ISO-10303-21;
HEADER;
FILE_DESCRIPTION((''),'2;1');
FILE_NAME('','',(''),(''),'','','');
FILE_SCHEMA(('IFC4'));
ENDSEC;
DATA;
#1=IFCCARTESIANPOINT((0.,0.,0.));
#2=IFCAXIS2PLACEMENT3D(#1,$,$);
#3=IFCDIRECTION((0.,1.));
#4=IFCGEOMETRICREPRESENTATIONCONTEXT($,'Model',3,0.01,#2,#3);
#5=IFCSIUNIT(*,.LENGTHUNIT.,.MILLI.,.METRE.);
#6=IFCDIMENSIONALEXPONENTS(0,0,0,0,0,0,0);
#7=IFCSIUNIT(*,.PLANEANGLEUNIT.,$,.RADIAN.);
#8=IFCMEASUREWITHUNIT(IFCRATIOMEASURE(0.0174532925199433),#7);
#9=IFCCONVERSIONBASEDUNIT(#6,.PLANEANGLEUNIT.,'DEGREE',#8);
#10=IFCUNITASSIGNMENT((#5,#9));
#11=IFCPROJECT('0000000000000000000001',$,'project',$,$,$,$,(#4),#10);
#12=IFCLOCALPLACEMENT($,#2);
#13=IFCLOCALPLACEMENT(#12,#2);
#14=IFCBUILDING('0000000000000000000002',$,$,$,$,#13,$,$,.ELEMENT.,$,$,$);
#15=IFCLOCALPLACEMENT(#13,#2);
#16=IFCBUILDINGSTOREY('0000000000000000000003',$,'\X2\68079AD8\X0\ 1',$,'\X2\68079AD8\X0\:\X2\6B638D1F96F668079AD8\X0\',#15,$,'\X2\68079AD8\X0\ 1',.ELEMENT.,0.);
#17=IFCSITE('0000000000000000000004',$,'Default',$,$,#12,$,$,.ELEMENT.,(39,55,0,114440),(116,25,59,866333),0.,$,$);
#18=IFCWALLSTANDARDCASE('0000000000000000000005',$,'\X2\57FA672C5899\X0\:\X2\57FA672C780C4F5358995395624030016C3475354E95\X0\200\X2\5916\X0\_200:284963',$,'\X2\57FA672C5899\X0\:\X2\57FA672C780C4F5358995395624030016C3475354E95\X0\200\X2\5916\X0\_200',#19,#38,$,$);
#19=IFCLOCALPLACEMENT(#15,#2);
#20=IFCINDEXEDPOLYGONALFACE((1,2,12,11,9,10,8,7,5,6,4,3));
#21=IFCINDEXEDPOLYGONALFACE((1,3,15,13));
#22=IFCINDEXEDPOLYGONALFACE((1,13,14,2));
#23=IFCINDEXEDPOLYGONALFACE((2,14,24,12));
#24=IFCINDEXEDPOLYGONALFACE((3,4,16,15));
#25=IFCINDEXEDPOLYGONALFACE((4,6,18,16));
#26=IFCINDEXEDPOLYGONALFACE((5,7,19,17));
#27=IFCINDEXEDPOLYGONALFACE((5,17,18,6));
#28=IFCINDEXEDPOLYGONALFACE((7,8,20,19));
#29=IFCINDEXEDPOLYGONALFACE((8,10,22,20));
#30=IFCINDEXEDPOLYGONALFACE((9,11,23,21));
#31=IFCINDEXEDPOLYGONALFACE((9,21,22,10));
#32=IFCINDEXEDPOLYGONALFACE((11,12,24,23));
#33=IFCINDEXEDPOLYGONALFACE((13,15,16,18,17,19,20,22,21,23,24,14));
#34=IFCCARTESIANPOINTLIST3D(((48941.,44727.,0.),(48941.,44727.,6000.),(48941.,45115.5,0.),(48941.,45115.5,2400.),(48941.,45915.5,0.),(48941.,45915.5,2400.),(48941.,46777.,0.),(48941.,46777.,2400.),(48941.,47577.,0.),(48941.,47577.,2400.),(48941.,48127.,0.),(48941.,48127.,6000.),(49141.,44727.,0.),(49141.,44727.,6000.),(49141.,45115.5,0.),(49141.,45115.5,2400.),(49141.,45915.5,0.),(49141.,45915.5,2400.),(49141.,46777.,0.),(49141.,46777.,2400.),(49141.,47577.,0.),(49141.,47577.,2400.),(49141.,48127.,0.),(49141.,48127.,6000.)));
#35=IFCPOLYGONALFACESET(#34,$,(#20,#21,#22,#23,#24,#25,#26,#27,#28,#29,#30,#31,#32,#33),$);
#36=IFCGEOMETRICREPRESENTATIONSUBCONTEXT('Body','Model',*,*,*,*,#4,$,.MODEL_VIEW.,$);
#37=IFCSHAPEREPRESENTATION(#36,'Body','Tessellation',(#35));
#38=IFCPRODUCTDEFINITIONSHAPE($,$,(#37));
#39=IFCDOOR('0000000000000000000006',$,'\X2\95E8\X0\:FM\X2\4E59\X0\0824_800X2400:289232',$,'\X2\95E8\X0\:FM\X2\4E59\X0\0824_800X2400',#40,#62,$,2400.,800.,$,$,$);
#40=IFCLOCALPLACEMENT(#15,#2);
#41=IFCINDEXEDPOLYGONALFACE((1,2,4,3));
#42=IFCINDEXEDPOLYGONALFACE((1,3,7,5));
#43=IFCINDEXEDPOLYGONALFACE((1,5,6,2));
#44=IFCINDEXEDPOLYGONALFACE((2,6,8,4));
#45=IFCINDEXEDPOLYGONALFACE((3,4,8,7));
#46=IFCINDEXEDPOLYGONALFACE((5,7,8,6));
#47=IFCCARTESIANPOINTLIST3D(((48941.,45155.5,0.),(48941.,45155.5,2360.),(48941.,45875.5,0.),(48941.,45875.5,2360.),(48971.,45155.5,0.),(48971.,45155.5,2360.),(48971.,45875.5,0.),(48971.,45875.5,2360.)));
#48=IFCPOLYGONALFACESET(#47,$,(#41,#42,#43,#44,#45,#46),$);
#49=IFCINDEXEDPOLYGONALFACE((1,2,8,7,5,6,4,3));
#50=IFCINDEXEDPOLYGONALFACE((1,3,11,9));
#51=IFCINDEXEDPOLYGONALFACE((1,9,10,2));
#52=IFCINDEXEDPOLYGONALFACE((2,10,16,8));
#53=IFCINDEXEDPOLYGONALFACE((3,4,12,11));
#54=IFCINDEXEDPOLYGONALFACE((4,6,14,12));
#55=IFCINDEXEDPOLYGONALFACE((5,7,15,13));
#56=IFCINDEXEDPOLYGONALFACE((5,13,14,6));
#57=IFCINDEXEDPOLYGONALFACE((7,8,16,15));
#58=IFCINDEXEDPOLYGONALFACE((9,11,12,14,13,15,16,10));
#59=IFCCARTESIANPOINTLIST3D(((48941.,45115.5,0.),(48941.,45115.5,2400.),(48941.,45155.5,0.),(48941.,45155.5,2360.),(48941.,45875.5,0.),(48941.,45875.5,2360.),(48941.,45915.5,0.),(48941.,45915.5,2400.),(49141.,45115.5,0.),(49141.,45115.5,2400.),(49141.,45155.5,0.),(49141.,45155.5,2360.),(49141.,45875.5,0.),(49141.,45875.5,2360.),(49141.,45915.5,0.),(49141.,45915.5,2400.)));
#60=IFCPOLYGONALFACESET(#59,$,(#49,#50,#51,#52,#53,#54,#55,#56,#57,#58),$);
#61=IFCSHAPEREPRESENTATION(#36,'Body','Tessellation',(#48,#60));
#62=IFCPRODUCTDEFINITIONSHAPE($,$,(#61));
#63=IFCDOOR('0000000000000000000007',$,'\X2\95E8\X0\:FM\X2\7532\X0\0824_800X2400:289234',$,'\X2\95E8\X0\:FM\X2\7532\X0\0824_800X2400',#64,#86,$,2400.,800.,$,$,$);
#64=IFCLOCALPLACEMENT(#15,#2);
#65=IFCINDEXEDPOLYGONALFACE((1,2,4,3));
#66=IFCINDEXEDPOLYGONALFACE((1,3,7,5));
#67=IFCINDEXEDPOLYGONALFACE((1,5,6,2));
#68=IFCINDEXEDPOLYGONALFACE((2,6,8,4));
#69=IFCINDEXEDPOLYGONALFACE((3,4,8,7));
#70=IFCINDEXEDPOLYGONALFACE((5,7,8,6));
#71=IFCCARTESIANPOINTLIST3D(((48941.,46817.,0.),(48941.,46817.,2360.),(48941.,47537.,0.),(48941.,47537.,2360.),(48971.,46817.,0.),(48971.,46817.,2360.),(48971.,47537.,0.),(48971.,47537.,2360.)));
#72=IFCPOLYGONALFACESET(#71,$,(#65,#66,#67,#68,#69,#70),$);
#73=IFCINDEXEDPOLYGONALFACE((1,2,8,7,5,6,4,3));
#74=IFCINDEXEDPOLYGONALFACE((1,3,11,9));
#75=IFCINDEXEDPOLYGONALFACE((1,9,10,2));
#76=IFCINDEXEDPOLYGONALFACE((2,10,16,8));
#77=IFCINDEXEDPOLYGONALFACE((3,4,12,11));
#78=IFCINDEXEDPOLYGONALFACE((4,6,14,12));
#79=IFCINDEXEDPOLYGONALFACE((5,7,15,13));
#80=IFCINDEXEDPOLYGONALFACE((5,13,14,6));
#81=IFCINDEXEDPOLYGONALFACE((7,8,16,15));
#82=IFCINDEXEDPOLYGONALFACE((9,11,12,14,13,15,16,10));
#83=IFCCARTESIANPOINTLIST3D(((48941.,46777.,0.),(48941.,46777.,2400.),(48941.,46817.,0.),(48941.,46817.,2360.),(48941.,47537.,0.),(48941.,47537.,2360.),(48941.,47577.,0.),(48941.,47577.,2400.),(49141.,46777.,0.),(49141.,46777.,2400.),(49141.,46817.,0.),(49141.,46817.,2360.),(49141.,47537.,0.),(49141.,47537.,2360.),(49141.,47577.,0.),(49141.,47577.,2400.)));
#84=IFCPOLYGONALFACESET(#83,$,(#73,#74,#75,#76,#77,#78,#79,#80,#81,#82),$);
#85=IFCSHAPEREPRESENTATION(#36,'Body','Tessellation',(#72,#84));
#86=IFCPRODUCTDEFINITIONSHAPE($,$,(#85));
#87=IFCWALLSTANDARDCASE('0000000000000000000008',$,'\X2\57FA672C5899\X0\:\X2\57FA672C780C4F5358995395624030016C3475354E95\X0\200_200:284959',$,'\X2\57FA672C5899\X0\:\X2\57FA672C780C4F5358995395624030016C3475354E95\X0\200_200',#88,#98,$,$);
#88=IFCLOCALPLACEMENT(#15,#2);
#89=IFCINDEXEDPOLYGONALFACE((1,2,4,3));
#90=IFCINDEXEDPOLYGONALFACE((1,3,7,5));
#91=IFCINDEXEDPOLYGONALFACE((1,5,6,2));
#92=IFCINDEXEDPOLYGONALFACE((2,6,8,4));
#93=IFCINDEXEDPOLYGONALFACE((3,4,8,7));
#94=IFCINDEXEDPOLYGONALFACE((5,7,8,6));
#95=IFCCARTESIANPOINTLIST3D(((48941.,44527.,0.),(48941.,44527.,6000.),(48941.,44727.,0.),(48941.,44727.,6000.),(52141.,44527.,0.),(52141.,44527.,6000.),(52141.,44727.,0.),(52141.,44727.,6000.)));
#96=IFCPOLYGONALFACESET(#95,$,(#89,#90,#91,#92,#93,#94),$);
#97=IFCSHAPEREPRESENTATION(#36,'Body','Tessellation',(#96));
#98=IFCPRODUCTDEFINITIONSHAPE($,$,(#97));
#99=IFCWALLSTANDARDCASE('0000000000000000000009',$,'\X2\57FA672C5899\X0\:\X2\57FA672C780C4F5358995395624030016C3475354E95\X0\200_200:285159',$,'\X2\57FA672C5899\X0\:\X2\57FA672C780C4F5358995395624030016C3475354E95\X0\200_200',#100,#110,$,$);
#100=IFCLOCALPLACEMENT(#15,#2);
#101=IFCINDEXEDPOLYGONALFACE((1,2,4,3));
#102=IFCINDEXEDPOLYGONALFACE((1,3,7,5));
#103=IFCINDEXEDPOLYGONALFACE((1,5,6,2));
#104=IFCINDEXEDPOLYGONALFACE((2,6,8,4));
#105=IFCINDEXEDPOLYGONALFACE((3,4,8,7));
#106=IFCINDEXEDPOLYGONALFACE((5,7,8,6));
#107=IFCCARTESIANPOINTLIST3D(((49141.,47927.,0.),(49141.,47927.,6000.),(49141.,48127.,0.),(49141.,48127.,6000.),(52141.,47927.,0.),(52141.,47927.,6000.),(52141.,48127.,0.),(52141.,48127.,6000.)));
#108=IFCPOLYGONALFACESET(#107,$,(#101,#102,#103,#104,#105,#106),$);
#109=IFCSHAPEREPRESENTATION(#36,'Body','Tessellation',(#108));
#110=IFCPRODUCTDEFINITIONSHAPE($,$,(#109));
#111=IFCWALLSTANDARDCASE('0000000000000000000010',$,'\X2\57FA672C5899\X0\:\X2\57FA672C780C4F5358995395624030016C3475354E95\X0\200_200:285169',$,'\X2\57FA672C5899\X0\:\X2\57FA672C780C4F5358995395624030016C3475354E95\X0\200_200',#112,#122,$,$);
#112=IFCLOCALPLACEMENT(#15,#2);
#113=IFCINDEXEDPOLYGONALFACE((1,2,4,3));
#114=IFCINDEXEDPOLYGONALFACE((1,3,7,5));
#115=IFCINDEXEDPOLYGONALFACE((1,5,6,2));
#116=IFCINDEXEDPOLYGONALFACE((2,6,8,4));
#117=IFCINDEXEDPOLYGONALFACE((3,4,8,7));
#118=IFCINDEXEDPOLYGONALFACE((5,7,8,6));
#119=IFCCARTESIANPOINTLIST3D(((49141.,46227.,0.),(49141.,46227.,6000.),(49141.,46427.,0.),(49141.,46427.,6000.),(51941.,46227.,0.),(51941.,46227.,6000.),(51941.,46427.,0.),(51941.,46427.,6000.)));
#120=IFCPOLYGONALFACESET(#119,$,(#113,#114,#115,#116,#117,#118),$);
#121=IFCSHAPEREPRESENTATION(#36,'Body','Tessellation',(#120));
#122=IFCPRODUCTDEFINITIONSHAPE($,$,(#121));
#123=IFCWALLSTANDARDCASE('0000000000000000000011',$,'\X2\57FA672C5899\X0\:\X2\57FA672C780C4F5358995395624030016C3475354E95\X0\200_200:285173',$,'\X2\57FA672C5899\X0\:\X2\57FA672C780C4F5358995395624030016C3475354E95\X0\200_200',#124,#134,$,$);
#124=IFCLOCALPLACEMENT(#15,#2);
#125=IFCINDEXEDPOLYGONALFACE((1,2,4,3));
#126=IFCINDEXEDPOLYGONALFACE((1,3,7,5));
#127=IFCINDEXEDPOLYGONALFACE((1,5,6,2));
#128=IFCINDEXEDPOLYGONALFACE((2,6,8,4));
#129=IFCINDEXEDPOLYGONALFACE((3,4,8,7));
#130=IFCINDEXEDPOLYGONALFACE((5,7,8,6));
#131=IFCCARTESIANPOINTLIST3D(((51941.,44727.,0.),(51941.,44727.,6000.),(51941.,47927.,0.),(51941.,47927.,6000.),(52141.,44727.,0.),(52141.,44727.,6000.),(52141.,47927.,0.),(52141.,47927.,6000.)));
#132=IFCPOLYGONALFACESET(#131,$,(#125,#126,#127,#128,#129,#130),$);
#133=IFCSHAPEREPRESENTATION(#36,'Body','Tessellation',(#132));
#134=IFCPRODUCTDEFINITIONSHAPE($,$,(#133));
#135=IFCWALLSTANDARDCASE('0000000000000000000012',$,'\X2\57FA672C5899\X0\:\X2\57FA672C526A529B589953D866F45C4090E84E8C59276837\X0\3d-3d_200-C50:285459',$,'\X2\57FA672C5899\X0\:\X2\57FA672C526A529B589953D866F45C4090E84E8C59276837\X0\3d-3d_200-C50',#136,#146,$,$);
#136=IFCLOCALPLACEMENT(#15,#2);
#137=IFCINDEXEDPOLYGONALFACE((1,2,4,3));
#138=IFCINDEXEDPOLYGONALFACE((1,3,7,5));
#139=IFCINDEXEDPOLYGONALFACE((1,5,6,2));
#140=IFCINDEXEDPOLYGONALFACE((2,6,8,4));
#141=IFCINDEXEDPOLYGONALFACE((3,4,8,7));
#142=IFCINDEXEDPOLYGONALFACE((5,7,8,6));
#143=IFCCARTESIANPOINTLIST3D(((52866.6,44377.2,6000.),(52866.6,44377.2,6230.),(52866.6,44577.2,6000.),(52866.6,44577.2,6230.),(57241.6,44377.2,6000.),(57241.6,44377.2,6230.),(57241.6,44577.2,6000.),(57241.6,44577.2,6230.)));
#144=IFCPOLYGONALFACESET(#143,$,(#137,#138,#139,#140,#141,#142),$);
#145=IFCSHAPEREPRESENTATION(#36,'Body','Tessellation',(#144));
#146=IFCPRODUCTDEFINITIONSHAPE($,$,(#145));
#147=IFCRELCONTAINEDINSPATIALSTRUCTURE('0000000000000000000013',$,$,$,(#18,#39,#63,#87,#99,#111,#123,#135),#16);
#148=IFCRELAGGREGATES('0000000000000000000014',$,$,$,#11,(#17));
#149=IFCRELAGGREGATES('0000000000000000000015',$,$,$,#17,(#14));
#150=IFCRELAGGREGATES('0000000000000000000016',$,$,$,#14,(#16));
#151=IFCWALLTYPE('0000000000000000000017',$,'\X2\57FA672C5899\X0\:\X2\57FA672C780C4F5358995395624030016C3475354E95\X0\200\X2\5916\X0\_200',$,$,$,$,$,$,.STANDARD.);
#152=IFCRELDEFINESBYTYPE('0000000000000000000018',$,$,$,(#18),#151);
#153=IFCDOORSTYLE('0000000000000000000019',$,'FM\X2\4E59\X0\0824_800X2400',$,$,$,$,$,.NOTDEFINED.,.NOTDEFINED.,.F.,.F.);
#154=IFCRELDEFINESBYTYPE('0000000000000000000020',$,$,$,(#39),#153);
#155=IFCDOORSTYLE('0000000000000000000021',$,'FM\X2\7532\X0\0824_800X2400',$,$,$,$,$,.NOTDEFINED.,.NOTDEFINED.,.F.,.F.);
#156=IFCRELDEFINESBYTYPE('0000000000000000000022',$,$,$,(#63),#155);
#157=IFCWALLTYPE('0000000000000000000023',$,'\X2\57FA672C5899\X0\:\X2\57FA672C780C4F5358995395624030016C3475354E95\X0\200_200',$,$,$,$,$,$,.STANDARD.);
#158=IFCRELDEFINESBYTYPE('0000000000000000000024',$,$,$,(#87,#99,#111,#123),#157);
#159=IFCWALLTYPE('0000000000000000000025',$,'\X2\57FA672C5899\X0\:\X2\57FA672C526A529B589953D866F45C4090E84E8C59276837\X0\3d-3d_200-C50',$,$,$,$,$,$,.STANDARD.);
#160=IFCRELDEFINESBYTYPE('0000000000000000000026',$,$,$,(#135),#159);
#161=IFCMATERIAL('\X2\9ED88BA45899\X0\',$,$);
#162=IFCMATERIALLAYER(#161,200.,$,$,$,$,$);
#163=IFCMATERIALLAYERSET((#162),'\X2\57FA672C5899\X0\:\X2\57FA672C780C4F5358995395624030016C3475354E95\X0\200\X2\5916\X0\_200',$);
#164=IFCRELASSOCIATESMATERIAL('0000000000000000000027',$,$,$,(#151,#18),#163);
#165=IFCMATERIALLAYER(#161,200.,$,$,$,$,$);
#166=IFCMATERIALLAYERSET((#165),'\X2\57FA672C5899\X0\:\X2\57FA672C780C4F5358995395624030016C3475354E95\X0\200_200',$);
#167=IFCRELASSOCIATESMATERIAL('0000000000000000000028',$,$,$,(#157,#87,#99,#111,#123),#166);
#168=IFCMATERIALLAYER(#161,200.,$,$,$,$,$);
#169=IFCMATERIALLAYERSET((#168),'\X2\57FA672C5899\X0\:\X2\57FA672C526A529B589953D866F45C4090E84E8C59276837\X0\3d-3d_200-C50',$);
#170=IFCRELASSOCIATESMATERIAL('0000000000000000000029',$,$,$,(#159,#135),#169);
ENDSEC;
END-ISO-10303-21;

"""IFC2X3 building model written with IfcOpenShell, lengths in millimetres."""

from ifc_helpers import new_model, entity, si_unit, converted_unit, direction, frame, frame_2d, origin, place, context, subcontext, project, spatial, polyline, rectangle, outline, extrude, source, transform, mapped, material, layer, layer_set, layer_usage, type_object, type_shapes, element, fill, save


model = new_model("IFC2X3")

# Units and contexts
model_context = context("Model", 3, precision=0.01, world=origin(), true_north=direction((0.0, 1.0)))
body_context = subcontext(model_context, "Body", "Model", "MODEL_VIEW")
ifc_project = project(units=[si_unit("LENGTHUNIT", "METRE", prefix="MILLI"), converted_unit("PLANEANGLEUNIT", "DEGREE", entity("IfcRatioMeasure", 0.0174532925199433), si_unit("PLANEANGLEUNIT", "RADIAN"), dimensions=[0, 0, 0, 0, 0, 0, 0])], contexts=[model_context])

# Site, building, storey
site_placement = place(None, origin())
site = spatial("IfcSite", under=ifc_project, at=site_placement, Name="Default", CompositionType="ELEMENT", RefLatitude=(39, 55, 0, 114440), RefLongitude=(116, 25, 59, 866333), RefElevation=0.0)
building_placement = place(site_placement, origin())
building = spatial("IfcBuilding", under=site, at=building_placement, CompositionType="ELEMENT")
storey_placement = place(building_placement, origin())
storey = spatial("IfcBuildingStorey", under=building, at=storey_placement, Name="标高 1", ObjectType="标高:正负零标高", LongName="标高 1", CompositionType="ELEMENT", Elevation=0.0)

# Shared definitions
ifc_material = material(Name="默认墙")

# Wall, openings, doors
ifc_layer_1 = layer(ifc_material, 200.0)
ifc_layer_set_1 = layer_set([ifc_layer_1], Name="基本墙:基本砌体墙厕所、水电井200外_200")
ifc_layer_usage_1 = layer_usage(ifc_layer_set_1, "AXIS2", "NEGATIVE", 100.0)
wall_type_1 = type_object("IfcWallType", Name="基本墙:基本砌体墙厕所、水电井200外_200", PredefinedType="STANDARD", material=ifc_layer_set_1)
wall_1_placement = place(building_placement, frame((49041.0, 44727.0, 0.0), z_axis=(0.0, 0.0, 1.0), x_axis=(0.0, 1.0, 0.0)))
wall_1 = element("IfcWallStandardCase", 1, at=wall_1_placement, inside=storey, type_object=wall_type_1, material=ifc_layer_usage_1, Name="基本墙:基本砌体墙厕所、水电井200外_200:284963", ObjectType="基本墙:基本砌体墙厕所、水电井200外_200", context=body_context, shape_type="SweptSolid", body=[
    extrude(rectangle(XDim=3400.0, YDim=200.0, at=frame_2d((1700.0, 0.0), x_axis=(-1.0, 0.0))), origin(), (0.0, 0.0, 1.0), 6000.0),
])
opening_1_placement = place(wall_1_placement, frame((388.5, -100.0, 0.0)))
opening_1 = element("IfcOpeningElement", 2, at=opening_1_placement, cuts=wall_1, ObjectType="Opening", context=body_context, shape_type="SweptSolid", body=[
    extrude(rectangle(XDim=2400.0, YDim=800.0, at=frame_2d((1200.0, 400.0), x_axis=(1.0, 0.0))), frame((0.0, 0.0, 0.0), z_axis=(0.0, 1.0, 0.0), x_axis=(0.0, 0.0, 1.0)), (0.0, 0.0, 1.0), 200.0),
])
opening_2_placement = place(wall_1_placement, frame((2050.0, -100.0, 0.0)))
opening_2 = element("IfcOpeningElement", 3, at=opening_2_placement, cuts=wall_1, ObjectType="Opening", context=body_context, shape_type="SweptSolid", body=[
    extrude(rectangle(XDim=2400.0, YDim=800.0, at=frame_2d((1200.0, 400.0), x_axis=(1.0, 0.0))), frame((0.0, 0.0, 0.0), z_axis=(0.0, 1.0, 0.0), x_axis=(0.0, 0.0, 1.0)), (0.0, 0.0, 1.0), 200.0),
])
door_style_1 = type_object("IfcDoorStyle", Name="FM乙0824_800X2400", ConstructionType="NOTDEFINED", OperationType="NOTDEFINED", ParameterTakesPrecedence=False, Sizeable=False)
shared_shape_1 = source(origin(), body_context, "Body", "SweptSolid", [
    extrude(rectangle(XDim=30.0, YDim=720.0, at=frame_2d((0.0, 0.0), x_axis=(1.0, 0.0))), frame((400.0, -715.0, 0.0), z_axis=(0.0, 0.0, 1.0), x_axis=(0.0, 1.0, 0.0)), (0.0, 0.0, 1.0), 2360.0),
    extrude(outline(polyline([(-1170.0, 360.0), (1190.0, 360.0), (1190.0, 400.0), (-1210.0, 400.0), (-1210.0, -400.0), (1190.0, -400.0), (1190.0, -360.0), (-1170.0, -360.0), (-1170.0, 360.0)])), frame((400.0, -900.0, 1190.0), z_axis=(0.0, 1.0, 0.0), x_axis=(0.0, 0.0, -1.0)), (0.0, 0.0, 1.0), 200.0),
])
type_shapes(door_style_1, [shared_shape_1])
door_1_placement = place(opening_1_placement, frame((0.0, 900.0, 0.0)))
door_1 = element("IfcDoor", 4, at=door_1_placement, inside=storey, type_object=door_style_1, Name="门:FM乙0824_800X2400:289232", ObjectType="门:FM乙0824_800X2400", OverallHeight=2400.0, OverallWidth=800.0, context=body_context, shape_type="MappedRepresentation", body=[
    mapped(shared_shape_1, transform((0.0, 0.0, 0.0), scale=1.0)),
])
fill(opening_1, door_1)
door_style_2 = type_object("IfcDoorStyle", Name="FM甲0824_800X2400", ConstructionType="NOTDEFINED", OperationType="NOTDEFINED", ParameterTakesPrecedence=False, Sizeable=False)
shared_shape_2 = source(origin(), body_context, "Body", "SweptSolid", [
    extrude(rectangle(XDim=30.0, YDim=720.0, at=frame_2d((0.0, 0.0), x_axis=(1.0, 0.0))), frame((400.0, -715.0, 0.0), z_axis=(0.0, 0.0, 1.0), x_axis=(0.0, 1.0, 0.0)), (0.0, 0.0, 1.0), 2360.0),
    extrude(outline(polyline([(-1170.0, 360.0), (1190.0, 360.0), (1190.0, 400.0), (-1210.0, 400.0), (-1210.0, -400.0), (1190.0, -400.0), (1190.0, -360.0), (-1170.0, -360.0), (-1170.0, 360.0)])), frame((400.0, -900.0, 1190.0), z_axis=(0.0, 1.0, 0.0), x_axis=(0.0, 0.0, -1.0)), (0.0, 0.0, 1.0), 200.0),
])
type_shapes(door_style_2, [shared_shape_2])
door_2_placement = place(opening_2_placement, frame((0.0, 900.0, 0.0)))
door_2 = element("IfcDoor", 5, at=door_2_placement, inside=storey, type_object=door_style_2, Name="门:FM甲0824_800X2400:289234", ObjectType="门:FM甲0824_800X2400", OverallHeight=2400.0, OverallWidth=800.0, context=body_context, shape_type="MappedRepresentation", body=[
    mapped(shared_shape_2, transform((0.0, 0.0, 0.0), scale=1.0)),
])
fill(opening_2, door_2)

# Walls
ifc_layer_2 = layer(ifc_material, 200.0)
ifc_layer_set_2 = layer_set([ifc_layer_2], Name="基本墙:基本砌体墙厕所、水电井200_200")
ifc_layer_usage_2 = layer_usage(ifc_layer_set_2, "AXIS2", "NEGATIVE", 100.0)
wall_type_2 = type_object("IfcWallType", Name="基本墙:基本砌体墙厕所、水电井200_200", PredefinedType="STANDARD", material=ifc_layer_set_2)
wall_2_placement = place(building_placement, frame((48941.0, 44627.0, 0.0)))
element("IfcWallStandardCase", 6, at=wall_2_placement, inside=storey, type_object=wall_type_2, material=ifc_layer_usage_2, Name="基本墙:基本砌体墙厕所、水电井200_200:284959", ObjectType="基本墙:基本砌体墙厕所、水电井200_200", context=body_context, shape_type="SweptSolid", body=[
    extrude(rectangle(XDim=3200.0, YDim=200.0, at=frame_2d((1600.0, 0.0), x_axis=(-1.0, 0.0))), origin(), (0.0, 0.0, 1.0), 6000.0),
])
ifc_layer_usage_3 = layer_usage(ifc_layer_set_2, "AXIS2", "NEGATIVE", 100.0)
wall_3_placement = place(building_placement, frame((49141.0, 48027.0, 0.0)))
element("IfcWallStandardCase", 7, at=wall_3_placement, inside=storey, type_object=wall_type_2, material=ifc_layer_usage_3, Name="基本墙:基本砌体墙厕所、水电井200_200:285159", ObjectType="基本墙:基本砌体墙厕所、水电井200_200", context=body_context, shape_type="SweptSolid", body=[
    extrude(rectangle(XDim=3000.0, YDim=200.0, at=frame_2d((1500.0, 0.0), x_axis=(-1.0, 0.0))), origin(), (0.0, 0.0, 1.0), 6000.0),
])
ifc_layer_usage_4 = layer_usage(ifc_layer_set_2, "AXIS2", "NEGATIVE", 100.0)
wall_4_placement = place(building_placement, frame((49141.0, 46327.0, 0.0)))
element("IfcWallStandardCase", 8, at=wall_4_placement, inside=storey, type_object=wall_type_2, material=ifc_layer_usage_4, Name="基本墙:基本砌体墙厕所、水电井200_200:285169", ObjectType="基本墙:基本砌体墙厕所、水电井200_200", context=body_context, shape_type="SweptSolid", body=[
    extrude(rectangle(XDim=2800.0, YDim=200.0, at=frame_2d((1400.0, 0.0), x_axis=(-1.0, 0.0))), origin(), (0.0, 0.0, 1.0), 6000.0),
])
ifc_layer_usage_5 = layer_usage(ifc_layer_set_2, "AXIS2", "NEGATIVE", 100.0)
wall_5_placement = place(building_placement, frame((52041.0, 47927.0, 0.0), z_axis=(0.0, 0.0, 1.0), x_axis=(0.0, -1.0, 0.0)))
element("IfcWallStandardCase", 9, at=wall_5_placement, inside=storey, type_object=wall_type_2, material=ifc_layer_usage_5, Name="基本墙:基本砌体墙厕所、水电井200_200:285173", ObjectType="基本墙:基本砌体墙厕所、水电井200_200", context=body_context, shape_type="SweptSolid", body=[
    extrude(rectangle(XDim=3200.0, YDim=200.0, at=frame_2d((1600.0, 0.0), x_axis=(-1.0, 0.0))), origin(), (0.0, 0.0, 1.0), 6000.0),
])
ifc_layer_3 = layer(ifc_material, 200.0)
ifc_layer_set_3 = layer_set([ifc_layer_3], Name="基本墙:基本剪力墙变更局部二大样3d-3d_200-C50")
ifc_layer_usage_6 = layer_usage(ifc_layer_set_3, "AXIS2", "NEGATIVE", 100.0)
wall_type_3 = type_object("IfcWallType", Name="基本墙:基本剪力墙变更局部二大样3d-3d_200-C50", PredefinedType="STANDARD", material=ifc_layer_set_3)
wall_6_placement = place(building_placement, frame((52866.6, 44477.2, 6000.0)))
element("IfcWallStandardCase", 10, at=wall_6_placement, inside=storey, type_object=wall_type_3, material=ifc_layer_usage_6, Name="基本墙:基本剪力墙变更局部二大样3d-3d_200-C50:285459", ObjectType="基本墙:基本剪力墙变更局部二大样3d-3d_200-C50", context=body_context, shape_type="SweptSolid", body=[
    extrude(rectangle(XDim=4375.0, YDim=200.0, at=frame_2d((2187.5, 0.0), x_axis=(-1.0, 0.0))), origin(), (0.0, 0.0, 1.0), 230.0),
])

save(model, "model.ifc")
